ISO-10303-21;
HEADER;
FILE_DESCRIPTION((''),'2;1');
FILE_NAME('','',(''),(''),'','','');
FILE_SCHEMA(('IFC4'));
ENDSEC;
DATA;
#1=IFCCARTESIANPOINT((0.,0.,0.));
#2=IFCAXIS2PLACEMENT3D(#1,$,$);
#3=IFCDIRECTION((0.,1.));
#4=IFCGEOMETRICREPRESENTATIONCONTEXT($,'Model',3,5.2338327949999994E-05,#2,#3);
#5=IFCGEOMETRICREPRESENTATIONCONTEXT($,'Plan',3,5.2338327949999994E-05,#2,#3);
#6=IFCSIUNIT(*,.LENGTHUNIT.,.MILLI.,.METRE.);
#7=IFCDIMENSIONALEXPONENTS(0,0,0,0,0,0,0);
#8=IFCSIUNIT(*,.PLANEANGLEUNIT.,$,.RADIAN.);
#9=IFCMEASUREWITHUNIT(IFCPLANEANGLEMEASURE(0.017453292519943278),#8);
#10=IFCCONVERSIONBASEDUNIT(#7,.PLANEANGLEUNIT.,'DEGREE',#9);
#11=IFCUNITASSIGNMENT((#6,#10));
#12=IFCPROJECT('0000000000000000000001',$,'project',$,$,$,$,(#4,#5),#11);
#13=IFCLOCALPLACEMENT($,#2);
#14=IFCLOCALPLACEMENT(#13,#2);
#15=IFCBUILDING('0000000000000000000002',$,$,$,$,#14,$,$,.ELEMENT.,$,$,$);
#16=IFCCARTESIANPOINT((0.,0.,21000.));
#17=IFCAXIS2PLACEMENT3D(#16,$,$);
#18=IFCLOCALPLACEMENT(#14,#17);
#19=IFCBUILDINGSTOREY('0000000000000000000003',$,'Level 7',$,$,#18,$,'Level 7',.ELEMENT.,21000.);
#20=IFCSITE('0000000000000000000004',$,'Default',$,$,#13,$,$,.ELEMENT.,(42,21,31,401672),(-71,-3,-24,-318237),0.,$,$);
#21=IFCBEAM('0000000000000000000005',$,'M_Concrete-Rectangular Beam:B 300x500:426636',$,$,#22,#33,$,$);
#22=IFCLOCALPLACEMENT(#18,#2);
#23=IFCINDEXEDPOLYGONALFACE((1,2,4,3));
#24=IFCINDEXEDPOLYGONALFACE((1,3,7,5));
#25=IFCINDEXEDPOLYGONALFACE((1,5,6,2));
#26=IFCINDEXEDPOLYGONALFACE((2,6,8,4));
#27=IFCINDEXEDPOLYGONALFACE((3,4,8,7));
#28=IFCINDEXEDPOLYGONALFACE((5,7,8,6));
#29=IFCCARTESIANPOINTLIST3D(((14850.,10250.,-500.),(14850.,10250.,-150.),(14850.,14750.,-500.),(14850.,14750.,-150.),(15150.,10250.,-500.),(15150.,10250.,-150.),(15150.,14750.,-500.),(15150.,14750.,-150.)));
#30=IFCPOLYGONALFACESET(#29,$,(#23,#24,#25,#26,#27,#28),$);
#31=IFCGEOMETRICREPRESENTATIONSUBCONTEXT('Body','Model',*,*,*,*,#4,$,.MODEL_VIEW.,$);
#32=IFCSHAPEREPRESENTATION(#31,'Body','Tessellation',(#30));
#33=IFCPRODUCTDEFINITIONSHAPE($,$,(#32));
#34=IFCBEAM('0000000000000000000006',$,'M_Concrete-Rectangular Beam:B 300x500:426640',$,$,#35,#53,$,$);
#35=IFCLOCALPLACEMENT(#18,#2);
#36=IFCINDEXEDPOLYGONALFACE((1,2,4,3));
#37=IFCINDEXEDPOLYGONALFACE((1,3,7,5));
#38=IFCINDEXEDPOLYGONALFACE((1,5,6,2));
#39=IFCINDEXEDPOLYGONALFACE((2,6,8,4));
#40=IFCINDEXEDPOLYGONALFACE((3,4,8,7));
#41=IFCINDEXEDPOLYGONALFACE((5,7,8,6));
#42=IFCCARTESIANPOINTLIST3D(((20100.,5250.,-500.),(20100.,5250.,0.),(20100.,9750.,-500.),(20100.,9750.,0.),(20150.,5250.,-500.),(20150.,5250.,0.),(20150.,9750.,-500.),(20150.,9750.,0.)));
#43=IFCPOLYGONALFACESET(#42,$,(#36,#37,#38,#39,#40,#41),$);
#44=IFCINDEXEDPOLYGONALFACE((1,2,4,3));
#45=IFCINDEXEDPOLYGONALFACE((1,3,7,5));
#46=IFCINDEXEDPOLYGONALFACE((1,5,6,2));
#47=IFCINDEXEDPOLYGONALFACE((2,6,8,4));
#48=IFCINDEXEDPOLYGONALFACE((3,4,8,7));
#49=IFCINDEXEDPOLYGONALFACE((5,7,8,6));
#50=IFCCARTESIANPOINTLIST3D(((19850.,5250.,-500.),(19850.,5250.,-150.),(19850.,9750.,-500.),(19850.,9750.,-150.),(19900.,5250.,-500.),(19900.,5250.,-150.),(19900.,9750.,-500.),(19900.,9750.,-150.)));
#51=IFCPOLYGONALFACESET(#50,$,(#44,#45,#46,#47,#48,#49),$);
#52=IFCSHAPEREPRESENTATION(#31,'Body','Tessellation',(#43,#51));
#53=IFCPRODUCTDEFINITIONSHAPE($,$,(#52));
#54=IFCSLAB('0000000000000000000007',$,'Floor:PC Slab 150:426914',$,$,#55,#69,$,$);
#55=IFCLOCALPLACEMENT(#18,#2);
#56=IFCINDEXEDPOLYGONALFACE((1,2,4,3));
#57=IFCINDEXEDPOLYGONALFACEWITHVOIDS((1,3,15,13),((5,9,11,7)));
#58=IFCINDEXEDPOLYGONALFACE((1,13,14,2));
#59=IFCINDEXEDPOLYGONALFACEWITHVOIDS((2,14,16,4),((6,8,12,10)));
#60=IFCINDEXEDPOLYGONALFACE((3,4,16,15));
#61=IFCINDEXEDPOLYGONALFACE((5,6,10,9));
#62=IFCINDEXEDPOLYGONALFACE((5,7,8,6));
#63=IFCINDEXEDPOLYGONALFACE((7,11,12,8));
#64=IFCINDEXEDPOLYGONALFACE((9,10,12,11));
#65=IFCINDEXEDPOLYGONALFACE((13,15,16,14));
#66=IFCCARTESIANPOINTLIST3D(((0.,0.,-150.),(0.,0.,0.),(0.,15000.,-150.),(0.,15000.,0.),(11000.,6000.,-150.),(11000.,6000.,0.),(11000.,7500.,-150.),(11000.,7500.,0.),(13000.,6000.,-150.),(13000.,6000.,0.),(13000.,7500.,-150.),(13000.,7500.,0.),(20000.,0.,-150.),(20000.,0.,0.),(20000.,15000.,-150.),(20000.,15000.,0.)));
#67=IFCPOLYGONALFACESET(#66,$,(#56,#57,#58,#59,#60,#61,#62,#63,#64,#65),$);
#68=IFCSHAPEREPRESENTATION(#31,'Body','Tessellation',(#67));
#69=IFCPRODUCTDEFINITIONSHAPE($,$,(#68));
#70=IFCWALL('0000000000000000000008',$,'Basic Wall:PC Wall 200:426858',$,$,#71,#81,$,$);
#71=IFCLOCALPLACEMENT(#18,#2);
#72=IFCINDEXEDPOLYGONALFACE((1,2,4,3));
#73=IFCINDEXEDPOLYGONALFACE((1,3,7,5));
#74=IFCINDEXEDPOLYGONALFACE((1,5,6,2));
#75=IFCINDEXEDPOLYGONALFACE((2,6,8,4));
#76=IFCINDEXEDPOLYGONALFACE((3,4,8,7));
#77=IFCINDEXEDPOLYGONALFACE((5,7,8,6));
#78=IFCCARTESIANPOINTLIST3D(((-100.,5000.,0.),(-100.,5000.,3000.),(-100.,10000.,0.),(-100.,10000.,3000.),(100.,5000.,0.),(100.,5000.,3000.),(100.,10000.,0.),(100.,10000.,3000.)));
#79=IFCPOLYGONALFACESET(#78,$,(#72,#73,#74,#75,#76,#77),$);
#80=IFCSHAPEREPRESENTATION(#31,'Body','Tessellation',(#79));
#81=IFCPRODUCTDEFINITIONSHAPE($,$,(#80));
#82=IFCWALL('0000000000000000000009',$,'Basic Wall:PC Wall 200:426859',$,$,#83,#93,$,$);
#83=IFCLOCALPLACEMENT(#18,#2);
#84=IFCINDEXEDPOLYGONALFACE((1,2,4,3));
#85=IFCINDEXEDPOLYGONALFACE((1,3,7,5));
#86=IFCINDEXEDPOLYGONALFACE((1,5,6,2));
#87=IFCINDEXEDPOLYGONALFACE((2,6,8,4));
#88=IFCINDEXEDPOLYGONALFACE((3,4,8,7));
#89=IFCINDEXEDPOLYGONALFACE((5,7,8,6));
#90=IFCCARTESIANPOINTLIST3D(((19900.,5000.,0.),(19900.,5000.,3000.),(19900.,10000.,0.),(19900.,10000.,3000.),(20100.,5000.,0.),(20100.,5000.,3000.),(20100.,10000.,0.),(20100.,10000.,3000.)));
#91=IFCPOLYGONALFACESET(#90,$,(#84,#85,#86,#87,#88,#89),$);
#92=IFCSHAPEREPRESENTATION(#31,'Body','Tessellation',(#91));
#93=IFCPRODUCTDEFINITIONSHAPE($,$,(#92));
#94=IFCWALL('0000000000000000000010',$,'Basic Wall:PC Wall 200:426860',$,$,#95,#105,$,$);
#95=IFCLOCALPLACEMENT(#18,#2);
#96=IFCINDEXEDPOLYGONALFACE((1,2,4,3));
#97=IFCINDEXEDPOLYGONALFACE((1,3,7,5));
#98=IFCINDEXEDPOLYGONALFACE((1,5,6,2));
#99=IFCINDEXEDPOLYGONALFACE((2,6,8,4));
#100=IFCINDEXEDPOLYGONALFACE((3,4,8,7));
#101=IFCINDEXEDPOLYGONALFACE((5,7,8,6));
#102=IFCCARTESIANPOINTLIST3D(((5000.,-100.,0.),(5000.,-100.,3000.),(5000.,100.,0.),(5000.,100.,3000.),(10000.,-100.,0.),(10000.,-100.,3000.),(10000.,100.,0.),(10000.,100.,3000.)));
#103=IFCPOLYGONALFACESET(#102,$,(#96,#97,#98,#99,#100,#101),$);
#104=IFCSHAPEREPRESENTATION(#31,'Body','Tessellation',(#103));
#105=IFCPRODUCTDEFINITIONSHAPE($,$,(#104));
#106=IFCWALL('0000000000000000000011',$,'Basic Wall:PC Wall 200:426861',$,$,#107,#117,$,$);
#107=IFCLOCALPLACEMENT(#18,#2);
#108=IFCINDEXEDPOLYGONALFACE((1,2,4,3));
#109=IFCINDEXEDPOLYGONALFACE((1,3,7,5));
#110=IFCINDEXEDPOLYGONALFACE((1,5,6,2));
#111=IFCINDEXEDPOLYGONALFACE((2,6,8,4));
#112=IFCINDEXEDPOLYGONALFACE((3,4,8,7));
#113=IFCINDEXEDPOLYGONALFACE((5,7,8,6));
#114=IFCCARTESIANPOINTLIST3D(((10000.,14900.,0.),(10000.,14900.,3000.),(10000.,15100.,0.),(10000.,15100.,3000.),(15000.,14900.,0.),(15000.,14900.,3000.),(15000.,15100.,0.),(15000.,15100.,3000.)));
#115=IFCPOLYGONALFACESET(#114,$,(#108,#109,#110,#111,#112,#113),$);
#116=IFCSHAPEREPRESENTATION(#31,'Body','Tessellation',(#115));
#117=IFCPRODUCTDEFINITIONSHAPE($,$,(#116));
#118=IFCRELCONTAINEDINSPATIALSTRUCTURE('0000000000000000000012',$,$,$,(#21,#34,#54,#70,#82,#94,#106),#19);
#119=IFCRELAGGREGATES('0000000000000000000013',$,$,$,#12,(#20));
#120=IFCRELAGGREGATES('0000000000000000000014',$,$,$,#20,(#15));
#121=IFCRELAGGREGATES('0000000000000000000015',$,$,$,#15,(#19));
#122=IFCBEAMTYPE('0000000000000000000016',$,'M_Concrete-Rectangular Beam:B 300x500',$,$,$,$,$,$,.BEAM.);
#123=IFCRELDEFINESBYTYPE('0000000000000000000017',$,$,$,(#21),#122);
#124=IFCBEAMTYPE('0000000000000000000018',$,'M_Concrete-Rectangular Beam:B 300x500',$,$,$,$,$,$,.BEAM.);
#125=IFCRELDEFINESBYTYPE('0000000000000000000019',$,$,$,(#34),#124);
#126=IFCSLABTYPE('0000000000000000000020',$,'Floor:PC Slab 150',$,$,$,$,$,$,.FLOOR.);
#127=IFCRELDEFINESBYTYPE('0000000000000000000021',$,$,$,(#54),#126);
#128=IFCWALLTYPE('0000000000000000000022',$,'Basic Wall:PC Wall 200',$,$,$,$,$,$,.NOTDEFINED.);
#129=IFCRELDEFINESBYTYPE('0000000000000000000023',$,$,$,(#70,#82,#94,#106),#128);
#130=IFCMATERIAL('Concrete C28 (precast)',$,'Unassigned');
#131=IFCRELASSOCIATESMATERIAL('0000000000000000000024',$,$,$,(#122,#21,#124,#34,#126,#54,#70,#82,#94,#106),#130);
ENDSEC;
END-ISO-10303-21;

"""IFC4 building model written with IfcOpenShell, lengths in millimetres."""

from ifc_helpers import new_model, entity, si_unit, converted_unit, direction, frame, origin, place, context, subcontext, project, spatial, indexed_curve, outline, extrude, source, transform, mapped, material, type_object, type_shapes, element, save


model = new_model("IFC4")

# Units and contexts
model_context = context("Model", 3, precision=5.2338327949999994e-05, world=origin(), true_north=direction((0.0, 1.0)))
plan_context = context("Plan", 3, precision=5.2338327949999994e-05, world=origin(), true_north=direction((0.0, 1.0)))
body_context = subcontext(model_context, "Body", "Model", "MODEL_VIEW")
ifc_project = project(units=[si_unit("LENGTHUNIT", "METRE", prefix="MILLI"), converted_unit("PLANEANGLEUNIT", "DEGREE", entity("IfcPlaneAngleMeasure", 0.017453292519943278), si_unit("PLANEANGLEUNIT", "RADIAN"), dimensions=[0, 0, 0, 0, 0, 0, 0])], contexts=[model_context, plan_context])

# Site, building, storey
site_placement = place(None, origin())
site = spatial("IfcSite", under=ifc_project, at=site_placement, Name="Default", CompositionType="ELEMENT", RefLatitude=(42, 21, 31, 401672), RefLongitude=(-71, -3, -24, -318237), RefElevation=0.0)
building_placement = place(site_placement, origin())
building = spatial("IfcBuilding", under=site, at=building_placement, CompositionType="ELEMENT")
storey_placement = place(building_placement, frame((0.0, 0.0, 21000.0)))
storey = spatial("IfcBuildingStorey", under=building, at=storey_placement, Name="Level 7", LongName="Level 7", CompositionType="ELEMENT", Elevation=21000.0)

# Beams
ifc_material = material(Name="Concrete C28 (precast)", Category="Unassigned")
beam_type_1 = type_object("IfcBeamType", Name="M_Concrete-Rectangular Beam:B 300x500", PredefinedType="BEAM", material=ifc_material)
shared_shape_1 = source(origin(), body_context, "Body", "SweptSolid", [
    extrude(outline(indexed_curve([(-150.0, -175.0), (150.0, -175.0), (150.0, 175.0), (-150.0, 175.0), (-150.0, -175.0)], self_intersect=False)), frame((15000.0, 10250.0, 20675.0), z_axis=(0.0, 1.0, 0.0), x_axis=(-1.0, 0.0, 0.0)), (0.0, 0.0, 1.0), 4500.0),
])
type_shapes(beam_type_1, [shared_shape_1])
beam_1_placement = place(storey_placement, frame((0.0, 0.0, -21000.0)))
element("IfcBeam", 1, at=beam_1_placement, inside=storey, type_object=beam_type_1, material=ifc_material, Name="M_Concrete-Rectangular Beam:B 300x500:426636", context=body_context, shape_type="MappedRepresentation", body=[
    mapped(shared_shape_1, transform((0.0, 0.0, 0.0), scale=1.0)),
])
beam_type_2 = type_object("IfcBeamType", Name="M_Concrete-Rectangular Beam:B 300x500", PredefinedType="BEAM", material=ifc_material)
shared_shape_2 = source(origin(), body_context, "Body", "SweptSolid", [
    extrude(outline(indexed_curve([(-25.0, -250.0), (25.0, -250.0), (25.0, 250.0), (-25.0, 250.0), (-25.0, -250.0)], self_intersect=False)), frame((20125.0, 5250.0, 20750.0), z_axis=(0.0, 1.0, 0.0), x_axis=(-1.0, 0.0, 0.0)), (0.0, 0.0, 1.0), 4500.0),
    extrude(outline(indexed_curve([(-25.0, -175.0), (25.0, -175.0), (25.0, 175.0), (-25.0, 175.0), (-25.0, -175.0)], self_intersect=False)), frame((19875.0, 5250.0, 20675.0), z_axis=(0.0, 1.0, 0.0), x_axis=(-1.0, 0.0, 0.0)), (0.0, 0.0, 1.0), 4500.0),
])
type_shapes(beam_type_2, [shared_shape_2])
beam_2_placement = place(storey_placement, frame((0.0, 0.0, -21000.0)))
element("IfcBeam", 2, at=beam_2_placement, inside=storey, type_object=beam_type_2, material=ifc_material, Name="M_Concrete-Rectangular Beam:B 300x500:426640", context=body_context, shape_type="MappedRepresentation", body=[
    mapped(shared_shape_2, transform((0.0, 0.0, 0.0), scale=1.0)),
])

# Slab, opening
slab_type = type_object("IfcSlabType", Name="Floor:PC Slab 150", PredefinedType="FLOOR", material=ifc_material)
slab_placement = place(storey_placement, origin())
slab = element("IfcSlab", 3, at=slab_placement, inside=storey, type_object=slab_type, material=ifc_material, Name="Floor:PC Slab 150:426914", context=body_context, shape_type="SweptSolid", body=[
    extrude(outline(indexed_curve([(-7500.0, -10000.0), (7500.0, -10000.0), (7500.0, 10000.0), (-7500.0, 10000.0), (-7500.0, -10000.0)], self_intersect=False), holes=[indexed_curve([(-1500.0, -3000.0), (-1500.0, -1000.0), (0.0, -1000.0), (0.0, -3000.0), (-1500.0, -3000.0)], self_intersect=False)]), frame((10000.0, 7500.0, -150.0), z_axis=(0.0, 0.0, 1.0), x_axis=(0.0, 1.0, 0.0)), (0.0, 0.0, 1.0), 150.0),
])
opening_placement = place(slab_placement, origin())
element("IfcOpeningElement", 4, at=opening_placement, cuts=slab, PredefinedType="OPENING", context=body_context, shape_type="SweptSolid", body=[
    extrude(outline(indexed_curve([(13000.0, 6000.0), (13000.0, 7500.0), (11000.0, 7500.0), (11000.0, 6000.0), (13000.0, 6000.0)], self_intersect=False)), frame((0.0, 0.0, -21000.0)), (0.0, 0.0, 1.0), 20000.0),
])

# Walls
wall_type = type_object("IfcWallType", Name="Basic Wall:PC Wall 200", PredefinedType="NOTDEFINED")
wall_1_placement = place(storey_placement, frame((0.0, 5000.0, 0.0), z_axis=(0.0, 0.0, 1.0), x_axis=(0.0, 1.0, 0.0)))
element("IfcWall", 5, at=wall_1_placement, inside=storey, type_object=wall_type, material=ifc_material, Name="Basic Wall:PC Wall 200:426858", context=body_context, shape_type="SweptSolid", body=[
    extrude(outline(indexed_curve([(5000.0, 100.0), (0.0, 100.0), (0.0, -100.0), (5000.0, -100.0), (5000.0, 100.0)], self_intersect=False)), origin(), (0.0, 0.0, 1.0), 3000.0),
])
wall_2_placement = place(storey_placement, frame((20000.0, 5000.0, 0.0), z_axis=(0.0, 0.0, 1.0), x_axis=(0.0, 1.0, 0.0)))
element("IfcWall", 6, at=wall_2_placement, inside=storey, type_object=wall_type, material=ifc_material, Name="Basic Wall:PC Wall 200:426859", context=body_context, shape_type="SweptSolid", body=[
    extrude(outline(indexed_curve([(5000.0, 100.0), (0.0, 100.0), (0.0, -100.0), (5000.0, -100.0), (5000.0, 100.0)], self_intersect=False)), origin(), (0.0, 0.0, 1.0), 3000.0),
])
wall_3_placement = place(storey_placement, frame((5000.0, 0.0, 0.0)))
element("IfcWall", 7, at=wall_3_placement, inside=storey, type_object=wall_type, material=ifc_material, Name="Basic Wall:PC Wall 200:426860", context=body_context, shape_type="SweptSolid", body=[
    extrude(outline(indexed_curve([(5000.0, 100.0), (0.0, 100.0), (0.0, -100.0), (5000.0, -100.0), (5000.0, 100.0)], self_intersect=False)), origin(), (0.0, 0.0, 1.0), 3000.0),
])
wall_4_placement = place(storey_placement, frame((10000.0, 15000.0, 0.0)))
element("IfcWall", 8, at=wall_4_placement, inside=storey, type_object=wall_type, material=ifc_material, Name="Basic Wall:PC Wall 200:426861", context=body_context, shape_type="SweptSolid", body=[
    extrude(outline(indexed_curve([(5000.0, 100.0), (0.0, 100.0), (0.0, -100.0), (5000.0, -100.0), (5000.0, 100.0)], self_intersect=False)), origin(), (0.0, 0.0, 1.0), 3000.0),
])

save(model, "model.ifc")
